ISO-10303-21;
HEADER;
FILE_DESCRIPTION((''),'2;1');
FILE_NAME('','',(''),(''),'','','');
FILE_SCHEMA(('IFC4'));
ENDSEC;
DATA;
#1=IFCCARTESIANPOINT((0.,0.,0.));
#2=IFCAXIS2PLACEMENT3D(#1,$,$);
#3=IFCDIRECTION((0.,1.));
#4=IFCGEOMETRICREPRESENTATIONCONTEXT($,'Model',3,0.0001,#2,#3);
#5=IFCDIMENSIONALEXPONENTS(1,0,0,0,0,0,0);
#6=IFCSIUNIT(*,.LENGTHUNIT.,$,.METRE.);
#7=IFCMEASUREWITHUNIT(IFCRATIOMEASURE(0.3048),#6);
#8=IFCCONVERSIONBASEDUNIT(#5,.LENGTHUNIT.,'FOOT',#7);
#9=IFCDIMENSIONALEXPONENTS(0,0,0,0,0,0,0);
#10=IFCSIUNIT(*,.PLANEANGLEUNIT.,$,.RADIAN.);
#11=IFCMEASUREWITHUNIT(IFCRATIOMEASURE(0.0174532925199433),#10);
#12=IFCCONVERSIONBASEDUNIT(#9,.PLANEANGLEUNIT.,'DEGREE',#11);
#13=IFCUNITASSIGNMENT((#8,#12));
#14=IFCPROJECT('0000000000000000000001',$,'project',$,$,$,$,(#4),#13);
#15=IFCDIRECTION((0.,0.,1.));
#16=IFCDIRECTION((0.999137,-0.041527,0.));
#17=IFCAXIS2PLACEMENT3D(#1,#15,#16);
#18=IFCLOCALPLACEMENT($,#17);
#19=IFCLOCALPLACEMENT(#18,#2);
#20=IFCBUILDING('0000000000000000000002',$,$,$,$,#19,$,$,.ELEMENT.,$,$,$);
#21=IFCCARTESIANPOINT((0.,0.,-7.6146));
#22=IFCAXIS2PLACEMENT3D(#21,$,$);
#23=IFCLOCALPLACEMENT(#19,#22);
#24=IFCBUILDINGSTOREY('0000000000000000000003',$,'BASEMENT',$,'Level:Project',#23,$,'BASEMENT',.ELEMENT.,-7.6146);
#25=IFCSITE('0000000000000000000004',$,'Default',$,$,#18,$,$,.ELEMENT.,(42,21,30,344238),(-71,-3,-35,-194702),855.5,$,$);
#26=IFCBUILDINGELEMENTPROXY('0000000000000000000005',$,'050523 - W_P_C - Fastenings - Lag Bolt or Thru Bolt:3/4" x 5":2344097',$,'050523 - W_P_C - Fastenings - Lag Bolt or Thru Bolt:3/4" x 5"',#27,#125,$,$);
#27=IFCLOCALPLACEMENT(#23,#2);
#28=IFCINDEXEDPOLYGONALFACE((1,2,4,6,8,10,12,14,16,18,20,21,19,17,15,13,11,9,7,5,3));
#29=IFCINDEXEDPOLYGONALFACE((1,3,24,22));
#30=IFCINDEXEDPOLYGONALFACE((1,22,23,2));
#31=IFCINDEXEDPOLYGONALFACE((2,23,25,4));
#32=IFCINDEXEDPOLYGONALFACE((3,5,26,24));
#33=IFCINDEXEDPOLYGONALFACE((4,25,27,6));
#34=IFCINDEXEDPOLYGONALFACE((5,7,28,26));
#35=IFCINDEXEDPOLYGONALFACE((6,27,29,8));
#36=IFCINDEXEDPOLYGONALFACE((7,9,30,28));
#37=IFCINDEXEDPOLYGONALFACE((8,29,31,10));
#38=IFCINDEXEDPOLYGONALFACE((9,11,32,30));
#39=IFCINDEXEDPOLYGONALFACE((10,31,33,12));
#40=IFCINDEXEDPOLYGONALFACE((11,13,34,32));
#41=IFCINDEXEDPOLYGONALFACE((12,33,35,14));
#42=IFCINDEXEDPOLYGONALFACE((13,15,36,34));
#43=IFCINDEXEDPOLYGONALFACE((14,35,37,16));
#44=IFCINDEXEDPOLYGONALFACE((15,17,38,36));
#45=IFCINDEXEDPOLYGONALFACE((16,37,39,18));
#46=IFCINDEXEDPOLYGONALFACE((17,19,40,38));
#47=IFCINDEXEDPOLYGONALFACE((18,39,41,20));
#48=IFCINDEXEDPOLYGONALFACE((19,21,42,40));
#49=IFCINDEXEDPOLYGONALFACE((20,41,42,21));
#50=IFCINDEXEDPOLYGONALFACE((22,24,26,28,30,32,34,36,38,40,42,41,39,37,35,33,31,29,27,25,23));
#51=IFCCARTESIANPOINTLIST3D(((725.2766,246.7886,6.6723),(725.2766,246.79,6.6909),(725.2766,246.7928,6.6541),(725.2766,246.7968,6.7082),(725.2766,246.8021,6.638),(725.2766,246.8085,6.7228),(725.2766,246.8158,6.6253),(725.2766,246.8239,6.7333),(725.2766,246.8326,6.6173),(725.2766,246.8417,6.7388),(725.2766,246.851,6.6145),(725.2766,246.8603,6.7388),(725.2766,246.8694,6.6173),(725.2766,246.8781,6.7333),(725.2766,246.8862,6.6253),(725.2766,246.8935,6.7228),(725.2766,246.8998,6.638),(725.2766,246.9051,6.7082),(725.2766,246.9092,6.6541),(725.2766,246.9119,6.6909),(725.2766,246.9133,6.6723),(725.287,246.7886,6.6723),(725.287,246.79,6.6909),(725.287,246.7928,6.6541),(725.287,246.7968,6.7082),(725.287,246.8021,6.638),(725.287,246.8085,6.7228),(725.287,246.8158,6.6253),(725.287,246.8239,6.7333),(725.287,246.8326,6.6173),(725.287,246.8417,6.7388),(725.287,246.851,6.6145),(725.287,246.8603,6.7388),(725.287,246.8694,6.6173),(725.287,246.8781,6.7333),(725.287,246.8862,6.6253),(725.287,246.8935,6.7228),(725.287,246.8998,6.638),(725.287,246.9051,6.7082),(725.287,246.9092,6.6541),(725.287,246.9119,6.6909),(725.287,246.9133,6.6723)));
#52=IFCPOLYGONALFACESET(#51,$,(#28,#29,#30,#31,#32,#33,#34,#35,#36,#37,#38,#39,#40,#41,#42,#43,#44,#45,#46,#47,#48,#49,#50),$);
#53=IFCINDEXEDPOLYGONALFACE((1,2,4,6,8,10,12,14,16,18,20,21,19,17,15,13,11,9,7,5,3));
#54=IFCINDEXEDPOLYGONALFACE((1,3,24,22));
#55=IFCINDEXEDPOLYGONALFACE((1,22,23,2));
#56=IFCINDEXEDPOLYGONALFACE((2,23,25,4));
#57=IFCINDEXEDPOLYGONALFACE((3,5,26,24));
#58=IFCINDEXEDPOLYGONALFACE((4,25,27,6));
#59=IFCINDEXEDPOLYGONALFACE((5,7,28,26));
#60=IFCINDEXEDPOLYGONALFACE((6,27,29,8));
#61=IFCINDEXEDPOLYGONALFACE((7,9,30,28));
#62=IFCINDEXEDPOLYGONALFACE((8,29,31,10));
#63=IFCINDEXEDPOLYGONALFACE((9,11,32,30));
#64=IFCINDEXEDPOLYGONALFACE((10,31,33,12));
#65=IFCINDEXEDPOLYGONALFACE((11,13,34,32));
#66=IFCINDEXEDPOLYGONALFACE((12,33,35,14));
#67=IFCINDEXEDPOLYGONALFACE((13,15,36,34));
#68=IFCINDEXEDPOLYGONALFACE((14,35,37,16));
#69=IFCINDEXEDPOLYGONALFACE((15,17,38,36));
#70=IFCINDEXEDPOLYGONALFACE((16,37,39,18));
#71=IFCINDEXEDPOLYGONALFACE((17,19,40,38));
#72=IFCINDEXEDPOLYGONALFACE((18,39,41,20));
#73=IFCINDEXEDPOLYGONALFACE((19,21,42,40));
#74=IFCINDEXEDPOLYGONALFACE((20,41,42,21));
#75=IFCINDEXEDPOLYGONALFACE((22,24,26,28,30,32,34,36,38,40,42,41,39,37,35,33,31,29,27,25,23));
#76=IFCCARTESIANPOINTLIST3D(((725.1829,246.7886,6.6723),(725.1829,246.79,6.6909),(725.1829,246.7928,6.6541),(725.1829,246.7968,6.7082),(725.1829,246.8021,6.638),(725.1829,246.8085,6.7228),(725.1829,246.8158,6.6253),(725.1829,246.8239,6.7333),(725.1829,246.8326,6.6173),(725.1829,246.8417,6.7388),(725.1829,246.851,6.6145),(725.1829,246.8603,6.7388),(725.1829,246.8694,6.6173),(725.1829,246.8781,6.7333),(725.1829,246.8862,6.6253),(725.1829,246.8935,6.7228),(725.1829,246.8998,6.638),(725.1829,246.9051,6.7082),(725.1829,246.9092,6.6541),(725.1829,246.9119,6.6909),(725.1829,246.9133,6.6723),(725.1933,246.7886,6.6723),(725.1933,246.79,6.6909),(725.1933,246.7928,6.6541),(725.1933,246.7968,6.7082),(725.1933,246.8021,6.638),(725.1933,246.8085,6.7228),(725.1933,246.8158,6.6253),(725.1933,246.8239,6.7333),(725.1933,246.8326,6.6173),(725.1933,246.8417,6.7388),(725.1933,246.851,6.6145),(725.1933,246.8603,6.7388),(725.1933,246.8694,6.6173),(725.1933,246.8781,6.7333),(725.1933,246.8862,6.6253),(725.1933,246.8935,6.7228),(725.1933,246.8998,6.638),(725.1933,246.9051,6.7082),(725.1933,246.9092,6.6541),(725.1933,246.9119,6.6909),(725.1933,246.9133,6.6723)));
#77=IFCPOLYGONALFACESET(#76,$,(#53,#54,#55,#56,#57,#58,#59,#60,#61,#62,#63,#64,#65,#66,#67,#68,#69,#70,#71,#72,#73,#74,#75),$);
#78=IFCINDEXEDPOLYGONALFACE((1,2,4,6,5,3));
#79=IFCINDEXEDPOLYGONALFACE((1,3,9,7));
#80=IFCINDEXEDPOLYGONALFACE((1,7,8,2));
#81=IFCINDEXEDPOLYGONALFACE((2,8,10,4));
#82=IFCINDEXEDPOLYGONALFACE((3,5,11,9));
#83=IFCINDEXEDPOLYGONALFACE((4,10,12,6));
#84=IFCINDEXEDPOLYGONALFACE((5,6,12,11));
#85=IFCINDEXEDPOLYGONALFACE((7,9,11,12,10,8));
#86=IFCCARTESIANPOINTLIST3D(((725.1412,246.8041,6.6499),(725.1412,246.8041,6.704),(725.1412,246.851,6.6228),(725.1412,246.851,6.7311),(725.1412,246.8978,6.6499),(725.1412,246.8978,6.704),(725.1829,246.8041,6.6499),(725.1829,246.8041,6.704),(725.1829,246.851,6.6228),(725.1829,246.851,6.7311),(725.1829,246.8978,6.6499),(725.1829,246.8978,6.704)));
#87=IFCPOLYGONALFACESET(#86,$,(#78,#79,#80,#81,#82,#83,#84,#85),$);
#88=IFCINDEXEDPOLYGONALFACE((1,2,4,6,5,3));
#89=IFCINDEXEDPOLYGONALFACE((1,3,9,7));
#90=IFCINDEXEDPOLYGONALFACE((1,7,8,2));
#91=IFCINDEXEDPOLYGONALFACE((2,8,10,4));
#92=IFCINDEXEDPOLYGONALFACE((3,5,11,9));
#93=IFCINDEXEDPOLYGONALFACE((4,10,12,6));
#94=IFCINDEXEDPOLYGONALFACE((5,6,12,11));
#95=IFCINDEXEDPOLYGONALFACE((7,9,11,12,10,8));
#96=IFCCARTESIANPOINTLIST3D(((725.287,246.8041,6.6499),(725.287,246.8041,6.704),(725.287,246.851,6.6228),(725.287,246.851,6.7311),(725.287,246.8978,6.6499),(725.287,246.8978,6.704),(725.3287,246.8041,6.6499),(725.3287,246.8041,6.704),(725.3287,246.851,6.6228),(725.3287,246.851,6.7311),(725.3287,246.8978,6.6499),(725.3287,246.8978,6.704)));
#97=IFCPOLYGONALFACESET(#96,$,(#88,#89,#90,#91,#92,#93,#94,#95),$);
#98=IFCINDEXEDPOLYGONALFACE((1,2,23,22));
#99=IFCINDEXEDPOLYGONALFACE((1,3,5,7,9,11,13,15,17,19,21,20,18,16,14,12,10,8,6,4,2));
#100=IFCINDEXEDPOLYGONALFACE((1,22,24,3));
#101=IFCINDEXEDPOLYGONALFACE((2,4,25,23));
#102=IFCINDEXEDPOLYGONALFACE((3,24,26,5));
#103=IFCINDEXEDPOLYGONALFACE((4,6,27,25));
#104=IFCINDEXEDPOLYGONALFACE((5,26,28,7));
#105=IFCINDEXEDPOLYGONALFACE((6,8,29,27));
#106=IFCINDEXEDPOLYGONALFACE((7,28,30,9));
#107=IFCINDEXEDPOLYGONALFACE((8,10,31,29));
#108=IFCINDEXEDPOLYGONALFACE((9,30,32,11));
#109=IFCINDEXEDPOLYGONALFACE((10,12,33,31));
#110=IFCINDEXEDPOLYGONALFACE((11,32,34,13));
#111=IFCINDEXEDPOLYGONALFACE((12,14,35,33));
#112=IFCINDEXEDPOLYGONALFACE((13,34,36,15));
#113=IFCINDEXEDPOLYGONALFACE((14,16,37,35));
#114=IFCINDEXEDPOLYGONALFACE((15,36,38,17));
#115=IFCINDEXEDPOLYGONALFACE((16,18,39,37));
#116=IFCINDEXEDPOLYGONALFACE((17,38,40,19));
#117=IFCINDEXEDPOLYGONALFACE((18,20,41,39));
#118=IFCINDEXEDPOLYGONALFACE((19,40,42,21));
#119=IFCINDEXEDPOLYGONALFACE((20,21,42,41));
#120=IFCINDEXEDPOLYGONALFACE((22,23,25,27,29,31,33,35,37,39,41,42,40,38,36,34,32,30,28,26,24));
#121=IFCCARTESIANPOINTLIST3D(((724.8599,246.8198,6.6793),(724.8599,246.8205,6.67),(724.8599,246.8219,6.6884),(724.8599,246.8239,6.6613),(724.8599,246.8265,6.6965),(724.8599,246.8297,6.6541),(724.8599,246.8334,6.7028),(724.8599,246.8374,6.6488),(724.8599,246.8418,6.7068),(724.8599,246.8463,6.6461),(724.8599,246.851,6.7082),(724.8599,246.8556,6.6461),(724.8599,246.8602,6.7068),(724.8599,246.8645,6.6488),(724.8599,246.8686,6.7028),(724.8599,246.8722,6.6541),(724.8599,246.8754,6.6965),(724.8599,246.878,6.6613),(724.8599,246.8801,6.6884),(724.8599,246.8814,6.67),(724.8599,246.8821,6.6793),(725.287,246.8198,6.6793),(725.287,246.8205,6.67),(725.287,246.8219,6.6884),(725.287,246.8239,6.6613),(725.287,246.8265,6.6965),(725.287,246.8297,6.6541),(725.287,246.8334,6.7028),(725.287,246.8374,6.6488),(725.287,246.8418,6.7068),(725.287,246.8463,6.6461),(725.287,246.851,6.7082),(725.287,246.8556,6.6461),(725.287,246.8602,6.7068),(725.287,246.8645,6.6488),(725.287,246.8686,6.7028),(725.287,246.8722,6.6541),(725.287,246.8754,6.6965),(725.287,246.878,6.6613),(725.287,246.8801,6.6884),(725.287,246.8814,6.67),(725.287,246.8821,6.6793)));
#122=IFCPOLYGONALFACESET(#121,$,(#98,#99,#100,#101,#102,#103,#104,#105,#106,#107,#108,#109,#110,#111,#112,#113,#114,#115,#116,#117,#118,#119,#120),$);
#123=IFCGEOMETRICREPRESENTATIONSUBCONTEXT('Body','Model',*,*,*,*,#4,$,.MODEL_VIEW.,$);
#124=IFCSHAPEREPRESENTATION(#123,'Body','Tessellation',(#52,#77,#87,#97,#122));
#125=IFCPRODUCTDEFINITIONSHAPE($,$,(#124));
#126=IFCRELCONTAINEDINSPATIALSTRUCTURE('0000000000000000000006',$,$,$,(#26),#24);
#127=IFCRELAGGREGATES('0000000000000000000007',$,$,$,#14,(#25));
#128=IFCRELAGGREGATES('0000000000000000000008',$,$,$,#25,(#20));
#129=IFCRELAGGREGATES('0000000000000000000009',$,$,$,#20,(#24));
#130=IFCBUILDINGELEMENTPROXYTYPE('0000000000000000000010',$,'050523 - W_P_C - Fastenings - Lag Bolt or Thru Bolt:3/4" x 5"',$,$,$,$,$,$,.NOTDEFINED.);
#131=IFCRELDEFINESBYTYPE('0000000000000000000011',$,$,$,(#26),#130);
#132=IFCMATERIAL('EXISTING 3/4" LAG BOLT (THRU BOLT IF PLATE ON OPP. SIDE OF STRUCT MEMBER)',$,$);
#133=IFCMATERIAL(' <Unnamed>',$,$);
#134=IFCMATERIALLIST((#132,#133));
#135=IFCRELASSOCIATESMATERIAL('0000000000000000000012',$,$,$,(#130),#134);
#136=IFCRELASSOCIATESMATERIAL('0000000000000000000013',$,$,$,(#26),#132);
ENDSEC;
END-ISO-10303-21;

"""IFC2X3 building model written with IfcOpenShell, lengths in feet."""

from ifc_helpers import new_model, entity, si_unit, converted_unit, direction, frame, frame_2d, origin, place, context, subcontext, project, spatial, polyline, circle, outline, extrude, source, transform, mapped, material, material_list, type_object, type_shapes, element, save


model = new_model("IFC2X3")

# Units and contexts
model_context = context("Model", 3, precision=0.0001, world=origin(), true_north=direction((0.0, 1.0)))
body_context = subcontext(model_context, "Body", "Model", "MODEL_VIEW")
ifc_project = project(units=[converted_unit("LENGTHUNIT", "FOOT", entity("IfcRatioMeasure", 0.3048), si_unit("LENGTHUNIT", "METRE"), dimensions=[1, 0, 0, 0, 0, 0, 0]), converted_unit("PLANEANGLEUNIT", "DEGREE", entity("IfcRatioMeasure", 0.0174532925199433), si_unit("PLANEANGLEUNIT", "RADIAN"), dimensions=[0, 0, 0, 0, 0, 0, 0])], contexts=[model_context])

# Site, building, storey
site_placement = place(None, frame((0.0, 0.0, 0.0), z_axis=(0.0, 0.0, 1.0), x_axis=(0.999137, -0.041527, 0.0)))
site = spatial("IfcSite", under=ifc_project, at=site_placement, Name="Default", CompositionType="ELEMENT", RefLatitude=(42, 21, 30, 344238), RefLongitude=(-71, -3, -35, -194702), RefElevation=855.5)
building_placement = place(site_placement, origin())
building = spatial("IfcBuilding", under=site, at=building_placement, CompositionType="ELEMENT")
storey_placement = place(building_placement, frame((0.0, 0.0, -7.6146)))
storey = spatial("IfcBuildingStorey", under=building, at=storey_placement, Name="BASEMENT", ObjectType="Level:Project", LongName="BASEMENT", CompositionType="ELEMENT", Elevation=-7.6146)

# Building element proxy
ifc_material_1 = material(Name="EXISTING 3/4\" LAG BOLT (THRU BOLT IF PLATE ON OPP. SIDE OF STRUCT MEMBER)")
ifc_material_2 = material(Name=" <Unnamed>")
ifc_material_list_1 = material_list([ifc_material_1, ifc_material_2])
building_element_proxy_type_1 = type_object("IfcBuildingElementProxyType", Name="050523 - W_P_C - Fastenings - Lag Bolt or Thru Bolt:3/4\" x 5\"", PredefinedType="NOTDEFINED", material=ifc_material_list_1)
shared_shape_1 = source(origin(), body_context, "Body", "SweptSolid", [
    extrude(circle(Radius=0.0625, at=frame_2d((0.0, 0.0), x_axis=(1.0, 0.0))), frame((0.0, 0.0, 0.0), z_axis=(0.0, 0.0, 1.0), x_axis=(0.0, 1.0, 0.0)), (0.0, 0.0, 1.0), 0.0104),
    extrude(circle(Radius=0.0625, at=frame_2d((0.0, 0.0), x_axis=(1.0, 0.0))), frame((0.0, 0.0, -0.0938), z_axis=(0.0, 0.0, 1.0), x_axis=(0.0, 1.0, 0.0)), (0.0, 0.0, 1.0), 0.0104),
    extrude(outline(polyline([(-0.0271, -0.0469), (0.0271, -0.0469), (0.0541, 0.0), (0.0271, 0.0469), (-0.0271, 0.0469), (-0.0541, 0.0), (-0.0271, -0.0469)])), frame((0.0, 0.0, -0.1354), z_axis=(0.0, 0.0, 1.0), x_axis=(0.0, -1.0, 0.0)), (0.0, 0.0, 1.0), 0.0417),
    extrude(outline(polyline([(-0.0271, -0.0469), (0.0271, -0.0469), (0.0541, 0.0), (0.0271, 0.0469), (-0.0271, 0.0469), (-0.0541, 0.0), (-0.0271, -0.0469)])), frame((0.0, 0.0, 0.0104), z_axis=(0.0, 0.0, 1.0), x_axis=(0.866025, -0.5, 0.0)), (0.0, 0.0, 1.0), 0.0417),
    extrude(circle(Radius=0.0312, at=frame_2d((0.0, 0.0), x_axis=(1.0, 0.0))), frame((0.0, 0.0, -0.4167), z_axis=(0.0, 0.0, 1.0), x_axis=(0.0, -1.0, 0.0)), (0.0, 0.0, 1.0), 0.4271),
])
type_shapes(building_element_proxy_type_1, [shared_shape_1])
proxy_placement = place(storey_placement, frame((725.2766, 246.851, 6.677), z_axis=(1.0, 0.0, 0.0), x_axis=(0.0, -1.0, 0.0)))
element("IfcBuildingElementProxy", 1, at=proxy_placement, inside=storey, type_object=building_element_proxy_type_1, material=ifc_material_1, Name="050523 - W_P_C - Fastenings - Lag Bolt or Thru Bolt:3/4\" x 5\":2344097", ObjectType="050523 - W_P_C - Fastenings - Lag Bolt or Thru Bolt:3/4\" x 5\"", context=body_context, shape_type="MappedRepresentation", body=[
    mapped(shared_shape_1, transform((0.0, 0.0, 0.0), scale=1.0)),
])

save(model, "model.ifc")
